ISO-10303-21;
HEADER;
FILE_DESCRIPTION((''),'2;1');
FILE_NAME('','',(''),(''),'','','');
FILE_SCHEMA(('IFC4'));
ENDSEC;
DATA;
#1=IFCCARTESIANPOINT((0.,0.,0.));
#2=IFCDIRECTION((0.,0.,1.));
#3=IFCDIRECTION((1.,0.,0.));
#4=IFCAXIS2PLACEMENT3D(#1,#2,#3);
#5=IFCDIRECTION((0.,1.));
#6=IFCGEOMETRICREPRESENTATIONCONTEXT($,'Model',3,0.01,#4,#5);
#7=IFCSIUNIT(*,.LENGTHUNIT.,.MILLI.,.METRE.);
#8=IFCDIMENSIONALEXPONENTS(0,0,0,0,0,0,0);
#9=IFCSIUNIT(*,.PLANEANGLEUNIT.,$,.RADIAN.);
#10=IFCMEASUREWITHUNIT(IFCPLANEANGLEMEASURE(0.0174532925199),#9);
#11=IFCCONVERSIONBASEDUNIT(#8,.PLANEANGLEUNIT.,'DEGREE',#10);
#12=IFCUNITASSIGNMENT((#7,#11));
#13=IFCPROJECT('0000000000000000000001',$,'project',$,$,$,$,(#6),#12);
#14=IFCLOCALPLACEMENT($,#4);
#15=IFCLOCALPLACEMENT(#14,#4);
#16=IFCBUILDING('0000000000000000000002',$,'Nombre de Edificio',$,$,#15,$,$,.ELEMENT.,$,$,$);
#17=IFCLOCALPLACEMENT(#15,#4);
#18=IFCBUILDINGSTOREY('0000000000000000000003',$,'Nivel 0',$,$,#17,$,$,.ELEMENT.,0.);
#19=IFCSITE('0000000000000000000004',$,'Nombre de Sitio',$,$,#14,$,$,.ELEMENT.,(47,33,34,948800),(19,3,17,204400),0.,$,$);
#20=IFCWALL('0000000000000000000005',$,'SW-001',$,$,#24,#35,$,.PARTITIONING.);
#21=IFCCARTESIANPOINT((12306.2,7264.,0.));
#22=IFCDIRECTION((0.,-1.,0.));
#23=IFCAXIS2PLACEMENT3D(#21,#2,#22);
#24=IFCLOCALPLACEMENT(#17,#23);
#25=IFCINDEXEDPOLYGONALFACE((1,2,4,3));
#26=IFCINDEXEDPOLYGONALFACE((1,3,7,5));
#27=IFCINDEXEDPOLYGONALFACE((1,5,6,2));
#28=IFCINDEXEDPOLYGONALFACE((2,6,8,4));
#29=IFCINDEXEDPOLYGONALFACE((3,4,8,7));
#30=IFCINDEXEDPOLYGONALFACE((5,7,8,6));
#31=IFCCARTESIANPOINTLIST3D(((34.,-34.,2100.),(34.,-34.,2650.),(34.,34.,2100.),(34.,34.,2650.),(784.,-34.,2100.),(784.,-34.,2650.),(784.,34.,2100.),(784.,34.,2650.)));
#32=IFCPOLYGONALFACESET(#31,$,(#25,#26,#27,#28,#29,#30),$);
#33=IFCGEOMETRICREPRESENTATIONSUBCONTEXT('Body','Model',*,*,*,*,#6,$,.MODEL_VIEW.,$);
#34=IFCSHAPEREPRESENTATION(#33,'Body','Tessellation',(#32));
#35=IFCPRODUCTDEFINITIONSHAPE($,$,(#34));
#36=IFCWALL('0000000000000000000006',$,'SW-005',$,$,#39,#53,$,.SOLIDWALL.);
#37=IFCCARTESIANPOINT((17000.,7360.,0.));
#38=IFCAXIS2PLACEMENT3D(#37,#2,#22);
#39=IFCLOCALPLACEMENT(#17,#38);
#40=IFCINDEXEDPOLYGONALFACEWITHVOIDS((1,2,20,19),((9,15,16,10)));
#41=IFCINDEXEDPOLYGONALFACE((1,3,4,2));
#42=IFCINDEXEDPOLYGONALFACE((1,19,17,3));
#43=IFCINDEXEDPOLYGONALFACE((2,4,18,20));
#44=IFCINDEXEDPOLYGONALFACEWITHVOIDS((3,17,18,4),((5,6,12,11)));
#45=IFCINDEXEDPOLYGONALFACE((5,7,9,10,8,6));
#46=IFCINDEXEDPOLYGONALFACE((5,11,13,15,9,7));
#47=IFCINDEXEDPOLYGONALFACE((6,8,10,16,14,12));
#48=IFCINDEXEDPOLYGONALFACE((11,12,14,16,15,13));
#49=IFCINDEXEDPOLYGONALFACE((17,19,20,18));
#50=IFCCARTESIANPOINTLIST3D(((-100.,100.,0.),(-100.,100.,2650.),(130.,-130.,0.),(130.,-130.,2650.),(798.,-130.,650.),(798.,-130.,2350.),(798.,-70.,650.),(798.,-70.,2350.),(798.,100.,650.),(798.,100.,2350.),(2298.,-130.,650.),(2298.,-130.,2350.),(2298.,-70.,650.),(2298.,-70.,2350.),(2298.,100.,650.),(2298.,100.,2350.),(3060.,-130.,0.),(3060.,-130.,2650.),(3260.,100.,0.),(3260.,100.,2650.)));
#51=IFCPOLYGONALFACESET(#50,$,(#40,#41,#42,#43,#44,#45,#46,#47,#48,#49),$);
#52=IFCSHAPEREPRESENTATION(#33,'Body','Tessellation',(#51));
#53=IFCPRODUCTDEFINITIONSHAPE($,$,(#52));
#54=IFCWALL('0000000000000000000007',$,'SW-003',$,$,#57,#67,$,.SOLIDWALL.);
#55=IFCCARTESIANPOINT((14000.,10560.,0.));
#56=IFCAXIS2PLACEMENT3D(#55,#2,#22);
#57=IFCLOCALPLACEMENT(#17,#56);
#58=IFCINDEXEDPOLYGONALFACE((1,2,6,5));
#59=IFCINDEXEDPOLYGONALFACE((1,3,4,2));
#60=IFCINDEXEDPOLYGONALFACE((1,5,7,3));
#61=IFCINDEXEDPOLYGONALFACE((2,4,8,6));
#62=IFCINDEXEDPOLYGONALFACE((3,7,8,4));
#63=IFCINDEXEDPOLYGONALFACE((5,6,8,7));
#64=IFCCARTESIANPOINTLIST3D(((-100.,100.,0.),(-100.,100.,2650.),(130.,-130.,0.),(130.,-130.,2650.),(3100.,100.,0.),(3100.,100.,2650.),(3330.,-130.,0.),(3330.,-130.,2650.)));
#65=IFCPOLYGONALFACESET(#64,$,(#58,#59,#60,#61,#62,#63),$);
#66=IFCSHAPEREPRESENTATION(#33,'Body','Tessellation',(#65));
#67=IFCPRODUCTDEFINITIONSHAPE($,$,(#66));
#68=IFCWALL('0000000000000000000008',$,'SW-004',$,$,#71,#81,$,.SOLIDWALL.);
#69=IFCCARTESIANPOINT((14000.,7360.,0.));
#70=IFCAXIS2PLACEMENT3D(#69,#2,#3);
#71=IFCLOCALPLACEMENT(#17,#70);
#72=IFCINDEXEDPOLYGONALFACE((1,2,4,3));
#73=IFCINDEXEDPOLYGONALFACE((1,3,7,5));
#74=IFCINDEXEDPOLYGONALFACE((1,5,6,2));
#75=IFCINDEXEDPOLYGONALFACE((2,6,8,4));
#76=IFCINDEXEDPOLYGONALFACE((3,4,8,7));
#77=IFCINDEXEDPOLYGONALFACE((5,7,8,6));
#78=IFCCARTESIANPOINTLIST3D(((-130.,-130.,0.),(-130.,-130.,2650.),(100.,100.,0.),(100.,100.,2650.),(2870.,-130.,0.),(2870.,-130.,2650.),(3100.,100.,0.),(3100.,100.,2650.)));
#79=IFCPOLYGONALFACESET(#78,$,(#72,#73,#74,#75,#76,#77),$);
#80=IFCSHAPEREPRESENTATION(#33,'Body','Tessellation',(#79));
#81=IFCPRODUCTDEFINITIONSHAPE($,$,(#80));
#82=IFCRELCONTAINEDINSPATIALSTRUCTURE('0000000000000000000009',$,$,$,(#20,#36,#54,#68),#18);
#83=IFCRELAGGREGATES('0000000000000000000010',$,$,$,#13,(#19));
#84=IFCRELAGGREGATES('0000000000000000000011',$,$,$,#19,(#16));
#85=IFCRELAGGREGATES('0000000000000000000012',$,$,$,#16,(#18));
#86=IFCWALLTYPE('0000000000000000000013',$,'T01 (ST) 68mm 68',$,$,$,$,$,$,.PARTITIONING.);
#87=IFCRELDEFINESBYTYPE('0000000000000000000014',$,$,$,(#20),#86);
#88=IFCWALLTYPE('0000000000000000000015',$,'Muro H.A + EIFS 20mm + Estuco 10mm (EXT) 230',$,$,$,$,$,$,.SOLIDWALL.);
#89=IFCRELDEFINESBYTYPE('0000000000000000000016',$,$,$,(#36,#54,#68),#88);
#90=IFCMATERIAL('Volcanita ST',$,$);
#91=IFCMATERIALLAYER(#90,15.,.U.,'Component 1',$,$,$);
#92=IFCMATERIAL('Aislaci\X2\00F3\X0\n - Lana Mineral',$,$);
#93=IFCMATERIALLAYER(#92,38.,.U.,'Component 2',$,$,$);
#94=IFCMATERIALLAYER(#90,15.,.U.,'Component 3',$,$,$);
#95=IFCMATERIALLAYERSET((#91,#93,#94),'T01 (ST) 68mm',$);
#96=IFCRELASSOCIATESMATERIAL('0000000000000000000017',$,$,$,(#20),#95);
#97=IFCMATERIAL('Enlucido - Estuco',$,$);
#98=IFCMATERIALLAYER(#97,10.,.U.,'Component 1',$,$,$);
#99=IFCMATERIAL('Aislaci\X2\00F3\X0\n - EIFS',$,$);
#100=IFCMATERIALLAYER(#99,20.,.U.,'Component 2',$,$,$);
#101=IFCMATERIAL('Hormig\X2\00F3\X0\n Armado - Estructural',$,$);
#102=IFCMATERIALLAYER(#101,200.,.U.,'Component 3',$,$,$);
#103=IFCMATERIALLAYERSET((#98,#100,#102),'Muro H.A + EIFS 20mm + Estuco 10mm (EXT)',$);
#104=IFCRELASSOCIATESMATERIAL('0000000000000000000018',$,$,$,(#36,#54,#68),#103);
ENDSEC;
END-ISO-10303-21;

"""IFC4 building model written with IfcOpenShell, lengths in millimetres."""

from ifc_helpers import new_model, entity, si_unit, converted_unit, direction, frame, origin_with_axes, origin_2d_with_axis, place, context, subcontext, project, spatial, line, indexed_curve, rectangle, outline, extrude, material, layer, layer_set, layer_usage, type_object, element, save


model = new_model("IFC4")

# Units and contexts
model_context = context("Model", 3, precision=0.01, world=origin_with_axes(), true_north=direction((0.0, 1.0)))
body_context = subcontext(model_context, "Body", "Model", "MODEL_VIEW")
ifc_project = project(units=[si_unit("LENGTHUNIT", "METRE", prefix="MILLI"), converted_unit("PLANEANGLEUNIT", "DEGREE", entity("IfcPlaneAngleMeasure", 0.0174532925199), si_unit("PLANEANGLEUNIT", "RADIAN"), dimensions=[0, 0, 0, 0, 0, 0, 0])], contexts=[model_context])

# Site, building, storey
site_placement = place(None, origin_with_axes())
site = spatial("IfcSite", under=ifc_project, at=site_placement, Name="Nombre de Sitio", CompositionType="ELEMENT", RefLatitude=(47, 33, 34, 948800), RefLongitude=(19, 3, 17, 204400), RefElevation=0.0)
building_placement = place(site_placement, origin_with_axes())
building = spatial("IfcBuilding", under=site, at=building_placement, Name="Nombre de Edificio", CompositionType="ELEMENT")
storey_placement = place(building_placement, origin_with_axes())
storey = spatial("IfcBuildingStorey", under=building, at=storey_placement, Name="Nivel 0", CompositionType="ELEMENT", Elevation=0.0)

# Shared definitions
ifc_material_1 = material(Name="Volcanita ST")
ifc_material_2 = material(Name="Aislación - Lana Mineral")

# Shared definitions
ifc_layer_1 = layer(ifc_material_1, 15.0, ventilated="UNKNOWN", Name="Component 1")
ifc_layer_2 = layer(ifc_material_2, 38.0, ventilated="UNKNOWN", Name="Component 2")
ifc_layer_3 = layer(ifc_material_1, 15.0, ventilated="UNKNOWN", Name="Component 3")
ifc_layer_set_1 = layer_set([ifc_layer_1, ifc_layer_2, ifc_layer_3], Name="T01 (ST) 68mm")
wall_type_1 = type_object("IfcWallType", Name="T01 (ST) 68mm 68", PredefinedType="PARTITIONING")

# Wall, opening
ifc_layer_usage_1 = layer_usage(ifc_layer_set_1, "AXIS2", "POSITIVE", -34.0)
wall_1_placement = place(storey_placement, frame((12306.2, 7264.0, 0.0), z_axis=(0.0, 0.0, 1.0), x_axis=(0.0, -1.0, 0.0)))
wall_1 = element("IfcWall", 1, at=wall_1_placement, inside=storey, type_object=wall_type_1, material=ifc_layer_usage_1, Name="SW-001", PredefinedType="PARTITIONING", context=body_context, shape_type="SweptSolid", body=[
    extrude(outline(indexed_curve([(34.0, -34.0), (784.0, -34.0), (784.0, 34.0), (34.0, 34.0)], segments=[line(1, 2, 3, 4, 1)])), origin_with_axes(), (0.0, 0.0, 1.0), 2650.0),
])
opening_1_placement = place(wall_1_placement, frame((409.0, 0.0, 0.0), z_axis=(0.0, 0.0, 1.0), x_axis=(1.0, 0.0, 0.0)))
element("IfcOpeningElement", 2, at=opening_1_placement, cuts=wall_1, context=body_context, shape_type="SweptSolid", body=[
    extrude(rectangle(XDim=750.0, YDim=2100.0, at=origin_2d_with_axis()), frame((0.0, -68.0, 1050.0), z_axis=(0.0, -1.0, 0.0), x_axis=(-1.0, 0.0, 0.0)), (0.0, 0.0, -1.0), 204.0),
])

# Wall, opening
ifc_material_3 = material(Name="Enlucido - Estuco")
ifc_layer_4 = layer(ifc_material_3, 10.0, ventilated="UNKNOWN", Name="Component 1")
ifc_material_4 = material(Name="Aislación - EIFS")
ifc_layer_5 = layer(ifc_material_4, 20.0, ventilated="UNKNOWN", Name="Component 2")
ifc_material_5 = material(Name="Hormigón Armado - Estructural")
ifc_layer_6 = layer(ifc_material_5, 200.0, ventilated="UNKNOWN", Name="Component 3")
ifc_layer_set_2 = layer_set([ifc_layer_4, ifc_layer_5, ifc_layer_6], Name="Muro H.A + EIFS 20mm + Estuco 10mm (EXT)")
ifc_layer_usage_2 = layer_usage(ifc_layer_set_2, "AXIS2", "POSITIVE", -130.0)
wall_type_2 = type_object("IfcWallType", Name="Muro H.A + EIFS 20mm + Estuco 10mm (EXT) 230", PredefinedType="SOLIDWALL")
wall_2_placement = place(storey_placement, frame((17000.0, 7360.0, 0.0), z_axis=(0.0, 0.0, 1.0), x_axis=(0.0, -1.0, 0.0)))
wall_2 = element("IfcWall", 3, at=wall_2_placement, inside=storey, type_object=wall_type_2, material=ifc_layer_usage_2, Name="SW-005", PredefinedType="SOLIDWALL", context=body_context, shape_type="SweptSolid", body=[
    extrude(outline(indexed_curve([(130.0, -130.0), (3060.0, -130.0), (3260.0, 100.0), (-100.0, 100.0)], segments=[line(1, 2, 3, 4, 1)])), origin_with_axes(), (0.0, 0.0, 1.0), 2650.0),
])
opening_2_placement = place(wall_2_placement, frame((1548.0, 0.0, 650.0), z_axis=(0.0, 0.0, 1.0), x_axis=(1.0, 0.0, 0.0)))
element("IfcOpeningElement", 4, at=opening_2_placement, cuts=wall_2, context=body_context, shape_type="SweptSolid", body=[
    extrude(rectangle(XDim=1500.0, YDim=1700.0, at=origin_2d_with_axis()), frame((0.0, -70.0, 850.0), z_axis=(0.0, 1.0, 0.0), x_axis=(-1.0, 0.0, 0.0)), (0.0, 0.0, 1.0), 400.0),
    extrude(rectangle(XDim=1500.0, YDim=1700.0, at=origin_2d_with_axis()), frame((0.0, -70.0, 850.0), z_axis=(0.0, -1.0, 0.0), x_axis=(-1.0, 0.0, 0.0)), (0.0, 0.0, 1.0), 290.0),
])

# Walls
ifc_layer_usage_3 = layer_usage(ifc_layer_set_2, "AXIS2", "POSITIVE", -130.0)
wall_3_placement = place(storey_placement, frame((14000.0, 10560.0, 0.0), z_axis=(0.0, 0.0, 1.0), x_axis=(0.0, -1.0, 0.0)))
element("IfcWall", 5, at=wall_3_placement, inside=storey, type_object=wall_type_2, material=ifc_layer_usage_3, Name="SW-003", PredefinedType="SOLIDWALL", context=body_context, shape_type="SweptSolid", body=[
    extrude(outline(indexed_curve([(130.0, -130.0), (3330.0, -130.0), (3100.0, 100.0), (-100.0, 100.0)], segments=[line(1, 2, 3, 4, 1)])), origin_with_axes(), (0.0, 0.0, 1.0), 2650.0),
])
ifc_layer_usage_4 = layer_usage(ifc_layer_set_2, "AXIS2", "POSITIVE", -130.0)
wall_4_placement = place(storey_placement, frame((14000.0, 7360.0, 0.0), z_axis=(0.0, 0.0, 1.0), x_axis=(1.0, 0.0, 0.0)))
element("IfcWall", 6, at=wall_4_placement, inside=storey, type_object=wall_type_2, material=ifc_layer_usage_4, Name="SW-004", PredefinedType="SOLIDWALL", context=body_context, shape_type="SweptSolid", body=[
    extrude(outline(indexed_curve([(-130.0, -130.0), (2870.0, -130.0), (3100.0, 100.0), (100.0, 100.0)], segments=[line(1, 2, 3, 4, 1)])), origin_with_axes(), (0.0, 0.0, 1.0), 2650.0),
])

save(model, "model.ifc")
